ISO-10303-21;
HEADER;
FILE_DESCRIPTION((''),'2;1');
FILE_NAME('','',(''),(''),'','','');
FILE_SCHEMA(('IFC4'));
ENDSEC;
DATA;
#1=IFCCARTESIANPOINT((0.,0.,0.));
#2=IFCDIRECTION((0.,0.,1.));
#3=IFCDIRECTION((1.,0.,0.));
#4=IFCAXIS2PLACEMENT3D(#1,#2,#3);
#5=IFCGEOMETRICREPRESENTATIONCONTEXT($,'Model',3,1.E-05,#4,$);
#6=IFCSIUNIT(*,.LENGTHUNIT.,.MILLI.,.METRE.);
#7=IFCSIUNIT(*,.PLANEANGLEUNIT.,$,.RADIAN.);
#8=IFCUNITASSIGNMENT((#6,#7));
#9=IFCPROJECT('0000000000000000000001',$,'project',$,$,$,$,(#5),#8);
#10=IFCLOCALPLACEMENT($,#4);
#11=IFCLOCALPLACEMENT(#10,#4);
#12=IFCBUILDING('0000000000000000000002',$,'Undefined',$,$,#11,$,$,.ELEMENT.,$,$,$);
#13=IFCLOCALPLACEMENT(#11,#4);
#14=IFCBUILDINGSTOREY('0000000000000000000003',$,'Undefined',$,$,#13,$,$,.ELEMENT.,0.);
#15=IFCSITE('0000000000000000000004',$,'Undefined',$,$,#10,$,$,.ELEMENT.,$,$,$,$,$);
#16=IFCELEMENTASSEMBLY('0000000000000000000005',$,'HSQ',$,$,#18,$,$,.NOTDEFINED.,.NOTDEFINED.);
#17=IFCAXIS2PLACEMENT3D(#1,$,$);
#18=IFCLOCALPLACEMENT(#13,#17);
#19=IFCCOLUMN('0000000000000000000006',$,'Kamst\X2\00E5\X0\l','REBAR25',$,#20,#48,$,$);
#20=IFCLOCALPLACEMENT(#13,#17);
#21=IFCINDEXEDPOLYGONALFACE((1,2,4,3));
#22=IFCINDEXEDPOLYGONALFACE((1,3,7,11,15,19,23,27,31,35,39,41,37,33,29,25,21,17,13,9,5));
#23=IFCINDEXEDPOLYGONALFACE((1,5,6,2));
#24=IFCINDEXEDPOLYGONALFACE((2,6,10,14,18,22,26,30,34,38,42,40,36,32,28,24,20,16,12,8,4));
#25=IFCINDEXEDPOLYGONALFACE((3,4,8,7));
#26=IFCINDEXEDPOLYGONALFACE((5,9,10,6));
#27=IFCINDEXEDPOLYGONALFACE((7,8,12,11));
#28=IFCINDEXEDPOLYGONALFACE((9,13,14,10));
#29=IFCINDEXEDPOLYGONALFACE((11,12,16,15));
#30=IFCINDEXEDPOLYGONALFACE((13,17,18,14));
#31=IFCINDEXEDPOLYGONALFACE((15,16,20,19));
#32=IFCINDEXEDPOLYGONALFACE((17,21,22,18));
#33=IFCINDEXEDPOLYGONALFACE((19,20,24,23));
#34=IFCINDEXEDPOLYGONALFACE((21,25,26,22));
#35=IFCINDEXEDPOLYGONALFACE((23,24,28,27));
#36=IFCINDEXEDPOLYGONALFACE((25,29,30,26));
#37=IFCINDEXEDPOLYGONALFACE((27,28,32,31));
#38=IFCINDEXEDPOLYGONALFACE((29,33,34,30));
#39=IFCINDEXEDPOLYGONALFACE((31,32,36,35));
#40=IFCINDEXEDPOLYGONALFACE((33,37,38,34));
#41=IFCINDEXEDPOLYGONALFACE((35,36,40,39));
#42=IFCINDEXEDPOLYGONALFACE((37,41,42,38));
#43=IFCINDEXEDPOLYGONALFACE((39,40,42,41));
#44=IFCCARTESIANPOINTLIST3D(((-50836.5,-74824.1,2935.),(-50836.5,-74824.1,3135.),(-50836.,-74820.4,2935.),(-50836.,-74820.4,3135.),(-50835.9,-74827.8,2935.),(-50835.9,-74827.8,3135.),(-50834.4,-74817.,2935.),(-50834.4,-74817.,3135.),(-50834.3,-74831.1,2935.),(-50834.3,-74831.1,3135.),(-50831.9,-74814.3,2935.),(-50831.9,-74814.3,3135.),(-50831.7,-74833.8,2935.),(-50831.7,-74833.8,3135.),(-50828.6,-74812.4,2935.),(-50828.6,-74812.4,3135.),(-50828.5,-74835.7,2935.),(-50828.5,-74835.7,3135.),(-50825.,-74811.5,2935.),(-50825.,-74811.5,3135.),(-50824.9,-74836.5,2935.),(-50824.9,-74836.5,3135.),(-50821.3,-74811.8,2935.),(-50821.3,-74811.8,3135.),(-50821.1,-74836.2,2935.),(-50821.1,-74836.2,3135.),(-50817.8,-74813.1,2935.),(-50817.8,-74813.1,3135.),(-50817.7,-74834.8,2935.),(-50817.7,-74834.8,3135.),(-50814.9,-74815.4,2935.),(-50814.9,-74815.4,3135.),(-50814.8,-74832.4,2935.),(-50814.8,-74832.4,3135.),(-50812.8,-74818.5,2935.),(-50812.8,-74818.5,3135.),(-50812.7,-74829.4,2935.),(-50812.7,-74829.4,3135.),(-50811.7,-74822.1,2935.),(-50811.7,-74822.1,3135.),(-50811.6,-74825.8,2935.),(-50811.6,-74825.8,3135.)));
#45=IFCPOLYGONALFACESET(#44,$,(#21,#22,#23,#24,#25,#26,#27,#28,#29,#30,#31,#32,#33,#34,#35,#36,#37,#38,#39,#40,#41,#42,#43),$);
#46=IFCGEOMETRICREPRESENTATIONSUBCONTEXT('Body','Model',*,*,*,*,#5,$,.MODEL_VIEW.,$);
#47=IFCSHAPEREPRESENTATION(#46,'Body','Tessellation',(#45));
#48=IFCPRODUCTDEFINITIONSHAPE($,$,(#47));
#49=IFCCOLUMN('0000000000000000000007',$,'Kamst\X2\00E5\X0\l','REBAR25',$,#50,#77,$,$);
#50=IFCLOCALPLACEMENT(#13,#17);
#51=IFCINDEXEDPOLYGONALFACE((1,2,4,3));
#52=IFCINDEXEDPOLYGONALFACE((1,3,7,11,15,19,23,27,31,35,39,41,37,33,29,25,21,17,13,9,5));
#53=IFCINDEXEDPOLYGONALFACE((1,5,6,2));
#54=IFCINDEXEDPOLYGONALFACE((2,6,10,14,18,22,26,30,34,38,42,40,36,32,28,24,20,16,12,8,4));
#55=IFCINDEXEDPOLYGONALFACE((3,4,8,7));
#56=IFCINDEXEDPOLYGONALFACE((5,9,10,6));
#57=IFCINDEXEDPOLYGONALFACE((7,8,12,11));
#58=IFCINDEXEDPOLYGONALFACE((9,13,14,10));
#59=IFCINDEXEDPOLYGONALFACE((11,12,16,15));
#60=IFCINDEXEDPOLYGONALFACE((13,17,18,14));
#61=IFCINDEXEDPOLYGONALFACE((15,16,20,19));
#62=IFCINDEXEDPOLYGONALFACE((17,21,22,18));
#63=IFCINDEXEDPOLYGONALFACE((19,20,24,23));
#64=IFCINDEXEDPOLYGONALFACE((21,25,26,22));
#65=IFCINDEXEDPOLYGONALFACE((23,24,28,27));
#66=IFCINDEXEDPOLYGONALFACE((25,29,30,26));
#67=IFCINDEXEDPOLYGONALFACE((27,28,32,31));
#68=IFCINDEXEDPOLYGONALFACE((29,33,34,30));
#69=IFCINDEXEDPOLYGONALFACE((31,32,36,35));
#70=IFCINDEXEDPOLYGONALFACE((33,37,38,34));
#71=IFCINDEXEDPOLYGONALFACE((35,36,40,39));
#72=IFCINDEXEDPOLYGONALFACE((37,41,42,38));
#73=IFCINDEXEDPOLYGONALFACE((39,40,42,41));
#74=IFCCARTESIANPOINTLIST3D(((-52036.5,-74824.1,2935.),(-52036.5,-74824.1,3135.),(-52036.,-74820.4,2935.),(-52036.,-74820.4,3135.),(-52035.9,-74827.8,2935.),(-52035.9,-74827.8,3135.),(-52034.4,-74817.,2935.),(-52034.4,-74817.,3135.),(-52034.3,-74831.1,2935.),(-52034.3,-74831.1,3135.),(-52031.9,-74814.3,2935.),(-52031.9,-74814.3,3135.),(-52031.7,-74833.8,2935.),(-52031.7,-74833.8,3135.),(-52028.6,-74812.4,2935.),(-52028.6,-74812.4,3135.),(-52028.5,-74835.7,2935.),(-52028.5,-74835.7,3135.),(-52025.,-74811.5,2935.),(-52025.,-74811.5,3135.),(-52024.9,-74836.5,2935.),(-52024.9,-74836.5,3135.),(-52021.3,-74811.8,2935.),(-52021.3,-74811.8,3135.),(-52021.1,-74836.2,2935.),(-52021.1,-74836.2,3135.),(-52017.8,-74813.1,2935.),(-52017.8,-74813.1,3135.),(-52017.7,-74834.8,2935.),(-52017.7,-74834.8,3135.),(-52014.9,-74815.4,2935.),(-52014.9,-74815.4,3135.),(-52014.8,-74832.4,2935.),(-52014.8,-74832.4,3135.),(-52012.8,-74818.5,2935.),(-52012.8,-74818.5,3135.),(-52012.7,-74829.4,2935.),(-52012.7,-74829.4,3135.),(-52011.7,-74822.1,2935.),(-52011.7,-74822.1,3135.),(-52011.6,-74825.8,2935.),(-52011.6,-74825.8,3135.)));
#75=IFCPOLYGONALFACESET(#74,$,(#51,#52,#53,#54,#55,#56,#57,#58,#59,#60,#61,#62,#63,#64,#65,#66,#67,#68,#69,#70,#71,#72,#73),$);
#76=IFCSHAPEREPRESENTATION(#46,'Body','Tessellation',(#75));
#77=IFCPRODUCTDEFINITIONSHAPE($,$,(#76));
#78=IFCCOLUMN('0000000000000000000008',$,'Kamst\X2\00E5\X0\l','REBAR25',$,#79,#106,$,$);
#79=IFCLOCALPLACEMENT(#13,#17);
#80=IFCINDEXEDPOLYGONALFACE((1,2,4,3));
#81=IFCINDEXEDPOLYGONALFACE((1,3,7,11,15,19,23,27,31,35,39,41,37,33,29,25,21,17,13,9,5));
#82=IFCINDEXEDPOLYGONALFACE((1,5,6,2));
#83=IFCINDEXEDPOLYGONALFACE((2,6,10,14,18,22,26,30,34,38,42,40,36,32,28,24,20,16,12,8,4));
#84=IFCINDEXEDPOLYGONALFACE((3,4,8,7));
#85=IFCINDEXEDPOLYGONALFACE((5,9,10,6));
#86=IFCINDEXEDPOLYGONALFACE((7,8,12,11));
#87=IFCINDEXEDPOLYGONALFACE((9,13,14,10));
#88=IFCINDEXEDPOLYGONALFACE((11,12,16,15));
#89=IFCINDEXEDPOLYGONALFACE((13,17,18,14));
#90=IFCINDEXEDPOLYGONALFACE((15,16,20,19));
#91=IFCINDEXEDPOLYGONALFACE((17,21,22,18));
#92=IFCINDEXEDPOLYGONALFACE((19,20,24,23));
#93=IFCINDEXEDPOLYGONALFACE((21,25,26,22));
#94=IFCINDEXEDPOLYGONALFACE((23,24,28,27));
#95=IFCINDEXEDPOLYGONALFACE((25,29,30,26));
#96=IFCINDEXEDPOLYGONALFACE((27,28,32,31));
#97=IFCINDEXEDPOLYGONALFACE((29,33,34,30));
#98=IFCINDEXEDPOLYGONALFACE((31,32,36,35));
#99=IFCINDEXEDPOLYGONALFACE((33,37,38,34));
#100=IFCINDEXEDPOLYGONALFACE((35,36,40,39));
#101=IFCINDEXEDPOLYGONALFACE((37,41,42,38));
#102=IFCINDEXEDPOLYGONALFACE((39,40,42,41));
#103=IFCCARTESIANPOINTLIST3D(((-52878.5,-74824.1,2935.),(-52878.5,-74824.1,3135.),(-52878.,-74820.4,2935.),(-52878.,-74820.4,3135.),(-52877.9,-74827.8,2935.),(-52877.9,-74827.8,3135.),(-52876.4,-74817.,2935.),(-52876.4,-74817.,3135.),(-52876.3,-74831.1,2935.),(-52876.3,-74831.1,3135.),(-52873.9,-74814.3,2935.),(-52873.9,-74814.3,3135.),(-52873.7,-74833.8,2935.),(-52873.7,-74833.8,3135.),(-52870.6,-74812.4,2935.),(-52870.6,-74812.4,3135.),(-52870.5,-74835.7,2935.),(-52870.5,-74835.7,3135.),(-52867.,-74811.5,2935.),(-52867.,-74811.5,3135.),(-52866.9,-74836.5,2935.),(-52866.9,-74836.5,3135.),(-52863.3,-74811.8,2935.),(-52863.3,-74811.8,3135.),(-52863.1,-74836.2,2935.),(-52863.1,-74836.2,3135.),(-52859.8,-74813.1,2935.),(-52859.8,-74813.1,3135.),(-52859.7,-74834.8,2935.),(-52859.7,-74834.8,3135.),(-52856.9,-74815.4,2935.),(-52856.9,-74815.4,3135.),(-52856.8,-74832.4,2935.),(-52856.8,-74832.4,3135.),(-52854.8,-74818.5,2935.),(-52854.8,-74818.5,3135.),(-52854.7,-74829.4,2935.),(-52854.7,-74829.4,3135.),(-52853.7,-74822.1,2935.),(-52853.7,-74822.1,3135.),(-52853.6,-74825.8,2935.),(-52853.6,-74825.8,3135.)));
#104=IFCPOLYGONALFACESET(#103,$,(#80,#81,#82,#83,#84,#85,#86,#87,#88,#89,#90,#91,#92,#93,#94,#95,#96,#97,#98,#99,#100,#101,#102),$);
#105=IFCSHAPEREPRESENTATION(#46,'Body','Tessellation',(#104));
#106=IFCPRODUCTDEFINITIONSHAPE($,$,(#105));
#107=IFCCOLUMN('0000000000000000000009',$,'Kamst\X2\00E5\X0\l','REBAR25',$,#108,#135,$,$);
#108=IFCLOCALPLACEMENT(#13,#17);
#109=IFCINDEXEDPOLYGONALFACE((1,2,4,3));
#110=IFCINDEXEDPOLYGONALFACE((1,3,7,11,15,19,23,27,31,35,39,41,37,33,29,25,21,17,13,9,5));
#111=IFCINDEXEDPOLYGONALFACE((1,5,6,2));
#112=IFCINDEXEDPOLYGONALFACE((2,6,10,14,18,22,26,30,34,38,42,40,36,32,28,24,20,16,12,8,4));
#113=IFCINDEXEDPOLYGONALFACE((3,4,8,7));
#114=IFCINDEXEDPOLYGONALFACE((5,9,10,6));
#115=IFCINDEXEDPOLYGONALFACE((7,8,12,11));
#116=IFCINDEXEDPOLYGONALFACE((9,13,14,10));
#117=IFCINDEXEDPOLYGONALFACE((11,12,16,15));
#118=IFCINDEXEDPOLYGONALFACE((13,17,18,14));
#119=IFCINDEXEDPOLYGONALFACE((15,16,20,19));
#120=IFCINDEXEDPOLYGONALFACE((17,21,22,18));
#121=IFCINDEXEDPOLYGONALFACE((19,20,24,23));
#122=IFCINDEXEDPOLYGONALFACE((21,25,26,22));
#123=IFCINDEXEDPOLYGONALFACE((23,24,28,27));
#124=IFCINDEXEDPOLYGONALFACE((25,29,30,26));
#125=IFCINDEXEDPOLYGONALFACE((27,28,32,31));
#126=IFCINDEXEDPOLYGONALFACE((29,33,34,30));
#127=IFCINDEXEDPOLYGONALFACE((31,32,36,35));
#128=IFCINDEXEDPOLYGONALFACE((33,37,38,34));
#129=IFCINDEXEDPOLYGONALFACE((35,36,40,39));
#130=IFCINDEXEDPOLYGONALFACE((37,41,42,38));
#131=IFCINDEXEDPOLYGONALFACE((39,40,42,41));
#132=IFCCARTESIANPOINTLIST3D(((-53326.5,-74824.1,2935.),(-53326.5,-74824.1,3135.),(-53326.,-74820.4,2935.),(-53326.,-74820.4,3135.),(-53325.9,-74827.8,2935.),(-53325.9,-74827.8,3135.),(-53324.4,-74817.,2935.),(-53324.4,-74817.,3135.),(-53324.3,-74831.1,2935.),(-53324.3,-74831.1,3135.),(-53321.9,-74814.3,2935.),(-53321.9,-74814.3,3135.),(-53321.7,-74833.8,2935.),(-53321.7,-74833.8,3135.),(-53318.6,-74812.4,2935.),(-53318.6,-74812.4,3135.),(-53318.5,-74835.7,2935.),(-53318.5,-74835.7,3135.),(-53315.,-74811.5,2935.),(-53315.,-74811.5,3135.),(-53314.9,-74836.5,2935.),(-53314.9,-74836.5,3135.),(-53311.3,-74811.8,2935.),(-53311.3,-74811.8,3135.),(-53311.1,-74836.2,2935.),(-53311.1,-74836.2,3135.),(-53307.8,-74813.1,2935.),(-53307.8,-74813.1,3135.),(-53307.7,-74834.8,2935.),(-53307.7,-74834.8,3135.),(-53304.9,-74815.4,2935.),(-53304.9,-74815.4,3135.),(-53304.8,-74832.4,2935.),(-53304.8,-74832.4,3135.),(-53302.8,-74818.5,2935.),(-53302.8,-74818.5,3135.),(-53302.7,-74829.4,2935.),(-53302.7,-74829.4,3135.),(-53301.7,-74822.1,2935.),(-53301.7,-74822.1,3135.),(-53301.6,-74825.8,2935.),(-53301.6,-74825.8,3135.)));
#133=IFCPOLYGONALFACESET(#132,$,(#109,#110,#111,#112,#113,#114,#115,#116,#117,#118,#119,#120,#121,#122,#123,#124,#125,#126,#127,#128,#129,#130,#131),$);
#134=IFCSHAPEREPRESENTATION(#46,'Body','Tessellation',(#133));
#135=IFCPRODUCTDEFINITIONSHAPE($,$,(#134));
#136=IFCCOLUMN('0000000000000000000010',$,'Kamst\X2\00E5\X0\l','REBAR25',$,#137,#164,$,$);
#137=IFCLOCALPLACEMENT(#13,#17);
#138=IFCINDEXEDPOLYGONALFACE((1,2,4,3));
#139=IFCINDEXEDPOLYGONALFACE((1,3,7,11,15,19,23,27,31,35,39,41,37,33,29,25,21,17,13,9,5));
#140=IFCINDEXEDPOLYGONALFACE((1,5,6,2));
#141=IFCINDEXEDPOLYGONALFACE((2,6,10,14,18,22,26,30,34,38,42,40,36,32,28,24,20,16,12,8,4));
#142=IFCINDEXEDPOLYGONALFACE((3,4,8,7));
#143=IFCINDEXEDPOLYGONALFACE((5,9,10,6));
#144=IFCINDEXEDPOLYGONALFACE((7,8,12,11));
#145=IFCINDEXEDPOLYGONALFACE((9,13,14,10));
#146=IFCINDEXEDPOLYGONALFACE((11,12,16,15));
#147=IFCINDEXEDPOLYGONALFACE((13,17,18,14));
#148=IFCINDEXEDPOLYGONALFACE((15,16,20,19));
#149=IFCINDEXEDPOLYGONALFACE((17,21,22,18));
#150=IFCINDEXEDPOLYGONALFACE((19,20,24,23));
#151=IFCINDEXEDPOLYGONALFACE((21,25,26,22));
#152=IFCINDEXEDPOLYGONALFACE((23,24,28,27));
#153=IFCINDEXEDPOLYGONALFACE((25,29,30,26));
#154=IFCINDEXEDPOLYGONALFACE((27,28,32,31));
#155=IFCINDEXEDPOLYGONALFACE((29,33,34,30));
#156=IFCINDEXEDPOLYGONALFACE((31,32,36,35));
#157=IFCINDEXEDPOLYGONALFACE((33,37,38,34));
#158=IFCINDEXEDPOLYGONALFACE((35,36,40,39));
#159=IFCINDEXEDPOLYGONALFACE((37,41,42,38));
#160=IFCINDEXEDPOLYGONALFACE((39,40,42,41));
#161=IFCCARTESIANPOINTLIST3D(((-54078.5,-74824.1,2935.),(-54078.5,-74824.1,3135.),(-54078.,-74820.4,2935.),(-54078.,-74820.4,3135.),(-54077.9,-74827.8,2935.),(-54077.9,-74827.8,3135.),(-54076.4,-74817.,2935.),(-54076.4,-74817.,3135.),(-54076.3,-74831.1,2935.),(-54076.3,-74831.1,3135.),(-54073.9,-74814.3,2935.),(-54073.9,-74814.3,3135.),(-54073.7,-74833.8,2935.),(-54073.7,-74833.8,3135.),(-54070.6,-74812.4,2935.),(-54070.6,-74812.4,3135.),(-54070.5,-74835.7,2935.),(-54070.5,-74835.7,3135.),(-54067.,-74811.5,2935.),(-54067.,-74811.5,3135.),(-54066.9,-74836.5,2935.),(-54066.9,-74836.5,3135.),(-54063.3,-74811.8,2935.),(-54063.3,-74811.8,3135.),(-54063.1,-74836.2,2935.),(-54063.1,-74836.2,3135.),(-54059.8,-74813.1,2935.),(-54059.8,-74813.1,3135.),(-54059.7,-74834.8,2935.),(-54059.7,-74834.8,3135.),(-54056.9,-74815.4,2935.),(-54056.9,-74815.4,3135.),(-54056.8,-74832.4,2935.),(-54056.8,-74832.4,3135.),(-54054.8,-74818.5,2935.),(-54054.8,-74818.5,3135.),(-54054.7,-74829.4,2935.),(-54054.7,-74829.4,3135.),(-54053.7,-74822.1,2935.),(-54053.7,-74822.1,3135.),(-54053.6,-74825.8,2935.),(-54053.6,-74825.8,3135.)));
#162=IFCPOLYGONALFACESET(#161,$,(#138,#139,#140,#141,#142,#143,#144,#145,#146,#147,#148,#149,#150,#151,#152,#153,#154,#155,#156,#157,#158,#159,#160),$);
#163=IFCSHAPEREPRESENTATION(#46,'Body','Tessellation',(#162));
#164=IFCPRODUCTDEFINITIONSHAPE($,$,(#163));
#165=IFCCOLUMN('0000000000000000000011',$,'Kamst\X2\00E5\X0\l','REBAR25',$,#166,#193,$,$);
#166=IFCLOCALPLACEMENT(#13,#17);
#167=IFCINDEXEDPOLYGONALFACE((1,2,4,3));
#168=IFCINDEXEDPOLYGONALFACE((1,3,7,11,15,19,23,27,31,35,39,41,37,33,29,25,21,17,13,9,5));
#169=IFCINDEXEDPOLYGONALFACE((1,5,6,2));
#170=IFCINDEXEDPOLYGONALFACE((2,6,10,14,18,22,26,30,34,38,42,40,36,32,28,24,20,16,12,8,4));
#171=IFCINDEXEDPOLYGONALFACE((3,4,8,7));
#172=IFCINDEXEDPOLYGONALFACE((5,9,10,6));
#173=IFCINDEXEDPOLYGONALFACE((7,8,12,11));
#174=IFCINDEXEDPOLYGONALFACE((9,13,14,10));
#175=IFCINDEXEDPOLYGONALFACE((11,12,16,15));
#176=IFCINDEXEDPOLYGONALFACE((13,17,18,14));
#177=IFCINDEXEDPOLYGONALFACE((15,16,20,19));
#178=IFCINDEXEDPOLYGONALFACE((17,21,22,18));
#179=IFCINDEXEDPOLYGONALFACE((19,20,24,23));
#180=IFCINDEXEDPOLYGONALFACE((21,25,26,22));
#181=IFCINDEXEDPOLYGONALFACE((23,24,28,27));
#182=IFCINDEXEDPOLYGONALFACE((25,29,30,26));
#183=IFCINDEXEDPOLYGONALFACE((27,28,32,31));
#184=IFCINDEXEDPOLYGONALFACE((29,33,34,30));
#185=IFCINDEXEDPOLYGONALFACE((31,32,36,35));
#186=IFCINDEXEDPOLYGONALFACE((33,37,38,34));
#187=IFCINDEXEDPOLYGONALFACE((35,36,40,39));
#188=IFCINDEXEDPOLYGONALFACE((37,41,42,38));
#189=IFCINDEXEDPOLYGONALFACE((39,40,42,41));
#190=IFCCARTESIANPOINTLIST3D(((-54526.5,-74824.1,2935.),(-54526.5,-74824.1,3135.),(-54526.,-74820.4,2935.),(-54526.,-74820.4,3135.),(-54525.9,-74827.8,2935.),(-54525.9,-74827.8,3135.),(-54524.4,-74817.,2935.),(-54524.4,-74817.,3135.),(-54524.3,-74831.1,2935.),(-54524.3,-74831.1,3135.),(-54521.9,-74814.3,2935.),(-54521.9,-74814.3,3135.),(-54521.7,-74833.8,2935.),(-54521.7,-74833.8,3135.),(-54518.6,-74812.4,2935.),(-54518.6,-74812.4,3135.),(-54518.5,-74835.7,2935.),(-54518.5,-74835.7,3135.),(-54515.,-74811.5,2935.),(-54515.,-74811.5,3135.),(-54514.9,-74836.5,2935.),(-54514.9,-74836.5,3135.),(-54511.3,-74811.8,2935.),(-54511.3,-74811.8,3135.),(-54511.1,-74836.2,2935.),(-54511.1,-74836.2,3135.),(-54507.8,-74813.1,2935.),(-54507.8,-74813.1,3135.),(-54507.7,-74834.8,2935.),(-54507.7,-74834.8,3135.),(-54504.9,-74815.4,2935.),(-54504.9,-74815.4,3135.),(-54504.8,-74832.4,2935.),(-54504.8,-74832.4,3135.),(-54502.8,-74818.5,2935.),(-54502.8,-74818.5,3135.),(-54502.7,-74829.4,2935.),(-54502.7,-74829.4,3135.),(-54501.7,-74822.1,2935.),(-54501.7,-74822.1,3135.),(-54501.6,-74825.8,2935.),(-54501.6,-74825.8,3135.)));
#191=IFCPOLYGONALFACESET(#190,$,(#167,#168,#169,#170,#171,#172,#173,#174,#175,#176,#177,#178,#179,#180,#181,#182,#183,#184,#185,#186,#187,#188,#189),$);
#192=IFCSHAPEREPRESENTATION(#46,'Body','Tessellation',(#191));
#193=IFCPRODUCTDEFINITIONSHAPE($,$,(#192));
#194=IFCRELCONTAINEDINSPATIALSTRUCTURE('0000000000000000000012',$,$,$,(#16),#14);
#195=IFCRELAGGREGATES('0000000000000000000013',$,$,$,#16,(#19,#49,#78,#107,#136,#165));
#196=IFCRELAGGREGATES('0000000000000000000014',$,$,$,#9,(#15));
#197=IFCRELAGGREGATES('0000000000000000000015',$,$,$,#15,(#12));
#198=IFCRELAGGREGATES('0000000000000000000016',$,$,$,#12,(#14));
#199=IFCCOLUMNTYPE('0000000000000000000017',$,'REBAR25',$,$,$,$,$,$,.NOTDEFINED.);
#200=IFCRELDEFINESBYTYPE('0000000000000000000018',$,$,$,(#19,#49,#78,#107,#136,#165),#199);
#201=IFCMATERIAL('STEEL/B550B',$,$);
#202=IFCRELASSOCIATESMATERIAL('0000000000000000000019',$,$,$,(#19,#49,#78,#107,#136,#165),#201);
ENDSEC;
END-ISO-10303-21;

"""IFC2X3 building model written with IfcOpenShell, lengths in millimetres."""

from ifc_helpers import new_model, si_unit, frame, origin_with_axes, origin_2d_with_axis, place, context, subcontext, project, spatial, circle, extrude, material, type_object, element, aggregate, save


model = new_model("IFC2X3")

# Units and contexts
model_context = context("Model", 3, precision=1e-05, world=origin_with_axes())
body_context = subcontext(model_context, "Body", "Model", "MODEL_VIEW")
ifc_project = project(units=[si_unit("LENGTHUNIT", "METRE", prefix="MILLI"), si_unit("PLANEANGLEUNIT", "RADIAN")], contexts=[model_context])

# Site, building, storey
site_placement = place(None, origin_with_axes())
site = spatial("IfcSite", under=ifc_project, at=site_placement, Name="Undefined", CompositionType="ELEMENT")
building_placement = place(site_placement, origin_with_axes())
building = spatial("IfcBuilding", under=site, at=building_placement, Name="Undefined", CompositionType="ELEMENT")
storey_placement = place(building_placement, origin_with_axes())
storey = spatial("IfcBuildingStorey", under=building, at=storey_placement, Name="Undefined", CompositionType="ELEMENT", Elevation=0.0)

# Element assembly, columns
assembly_1_placement = place(storey_placement, origin_with_axes())
assembly_1 = element("IfcElementAssembly", 1, at=assembly_1_placement, inside=storey, Name="HSQ", AssemblyPlace="NOTDEFINED", PredefinedType="NOTDEFINED")
ifc_material_1 = material(Name="STEEL/B550B")
column_type_1 = type_object("IfcColumnType", Name="REBAR25", PredefinedType="NOTDEFINED")
column_1_placement = place(assembly_1_placement, frame((-50824.0, -74824.0, 2935.0), z_axis=(0.0, 0.0, 1.0), x_axis=(-0.862746, -0.505638, 0.0)))
column_1 = element("IfcColumn", 2, at=column_1_placement, type_object=column_type_1, material=ifc_material_1, Name="Kamstål", Description="REBAR25", context=body_context, shape_type="SweptSolid", body=[
    extrude(circle(Radius=12.5, at=origin_2d_with_axis()), frame((0.0, 0.0, 200.0), z_axis=(0.0, 0.0, -1.0), x_axis=(0.0, 1.0, 0.0)), (0.0, 0.0, 1.0), 200.0),
])
column_2_placement = place(assembly_1_placement, frame((-52024.0, -74824.0, 2935.0), z_axis=(0.0, 0.0, 1.0), x_axis=(-0.862746, -0.505638, 0.0)))
column_2 = element("IfcColumn", 3, at=column_2_placement, type_object=column_type_1, material=ifc_material_1, Name="Kamstål", Description="REBAR25", context=body_context, shape_type="SweptSolid", body=[
    extrude(circle(Radius=12.5, at=origin_2d_with_axis()), frame((0.0, 0.0, 200.0), z_axis=(0.0, 0.0, -1.0), x_axis=(0.0, 1.0, 0.0)), (0.0, 0.0, 1.0), 200.0),
])
column_3_placement = place(assembly_1_placement, frame((-52866.0, -74824.0, 2935.0), z_axis=(0.0, 0.0, 1.0), x_axis=(-0.862746, -0.505638, 0.0)))
column_3 = element("IfcColumn", 4, at=column_3_placement, type_object=column_type_1, material=ifc_material_1, Name="Kamstål", Description="REBAR25", context=body_context, shape_type="SweptSolid", body=[
    extrude(circle(Radius=12.5, at=origin_2d_with_axis()), frame((0.0, 0.0, 200.0), z_axis=(0.0, 0.0, -1.0), x_axis=(0.0, 1.0, 0.0)), (0.0, 0.0, 1.0), 200.0),
])
column_4_placement = place(assembly_1_placement, frame((-53314.0, -74824.0, 2935.0), z_axis=(0.0, 0.0, 1.0), x_axis=(-0.862746, -0.505638, 0.0)))
column_4 = element("IfcColumn", 5, at=column_4_placement, type_object=column_type_1, material=ifc_material_1, Name="Kamstål", Description="REBAR25", context=body_context, shape_type="SweptSolid", body=[
    extrude(circle(Radius=12.5, at=origin_2d_with_axis()), frame((0.0, 0.0, 200.0), z_axis=(0.0, 0.0, -1.0), x_axis=(0.0, 1.0, 0.0)), (0.0, 0.0, 1.0), 200.0),
])
column_5_placement = place(assembly_1_placement, frame((-54066.0, -74824.0, 2935.0), z_axis=(0.0, 0.0, 1.0), x_axis=(-0.862746, -0.505638, 0.0)))
column_5 = element("IfcColumn", 6, at=column_5_placement, type_object=column_type_1, material=ifc_material_1, Name="Kamstål", Description="REBAR25", context=body_context, shape_type="SweptSolid", body=[
    extrude(circle(Radius=12.5, at=origin_2d_with_axis()), frame((0.0, 0.0, 200.0), z_axis=(0.0, 0.0, -1.0), x_axis=(0.0, 1.0, 0.0)), (0.0, 0.0, 1.0), 200.0),
])
column_6_placement = place(assembly_1_placement, frame((-54514.0, -74824.0, 2935.0), z_axis=(0.0, 0.0, 1.0), x_axis=(-0.862746, -0.505638, 0.0)))
column_6 = element("IfcColumn", 7, at=column_6_placement, type_object=column_type_1, material=ifc_material_1, Name="Kamstål", Description="REBAR25", context=body_context, shape_type="SweptSolid", body=[
    extrude(circle(Radius=12.5, at=origin_2d_with_axis()), frame((0.0, 0.0, 200.0), z_axis=(0.0, 0.0, -1.0), x_axis=(0.0, 1.0, 0.0)), (0.0, 0.0, 1.0), 200.0),
])

aggregate(assembly_1, [column_1, column_2, column_3, column_4, column_5, column_6])

save(model, "model.ifc")
